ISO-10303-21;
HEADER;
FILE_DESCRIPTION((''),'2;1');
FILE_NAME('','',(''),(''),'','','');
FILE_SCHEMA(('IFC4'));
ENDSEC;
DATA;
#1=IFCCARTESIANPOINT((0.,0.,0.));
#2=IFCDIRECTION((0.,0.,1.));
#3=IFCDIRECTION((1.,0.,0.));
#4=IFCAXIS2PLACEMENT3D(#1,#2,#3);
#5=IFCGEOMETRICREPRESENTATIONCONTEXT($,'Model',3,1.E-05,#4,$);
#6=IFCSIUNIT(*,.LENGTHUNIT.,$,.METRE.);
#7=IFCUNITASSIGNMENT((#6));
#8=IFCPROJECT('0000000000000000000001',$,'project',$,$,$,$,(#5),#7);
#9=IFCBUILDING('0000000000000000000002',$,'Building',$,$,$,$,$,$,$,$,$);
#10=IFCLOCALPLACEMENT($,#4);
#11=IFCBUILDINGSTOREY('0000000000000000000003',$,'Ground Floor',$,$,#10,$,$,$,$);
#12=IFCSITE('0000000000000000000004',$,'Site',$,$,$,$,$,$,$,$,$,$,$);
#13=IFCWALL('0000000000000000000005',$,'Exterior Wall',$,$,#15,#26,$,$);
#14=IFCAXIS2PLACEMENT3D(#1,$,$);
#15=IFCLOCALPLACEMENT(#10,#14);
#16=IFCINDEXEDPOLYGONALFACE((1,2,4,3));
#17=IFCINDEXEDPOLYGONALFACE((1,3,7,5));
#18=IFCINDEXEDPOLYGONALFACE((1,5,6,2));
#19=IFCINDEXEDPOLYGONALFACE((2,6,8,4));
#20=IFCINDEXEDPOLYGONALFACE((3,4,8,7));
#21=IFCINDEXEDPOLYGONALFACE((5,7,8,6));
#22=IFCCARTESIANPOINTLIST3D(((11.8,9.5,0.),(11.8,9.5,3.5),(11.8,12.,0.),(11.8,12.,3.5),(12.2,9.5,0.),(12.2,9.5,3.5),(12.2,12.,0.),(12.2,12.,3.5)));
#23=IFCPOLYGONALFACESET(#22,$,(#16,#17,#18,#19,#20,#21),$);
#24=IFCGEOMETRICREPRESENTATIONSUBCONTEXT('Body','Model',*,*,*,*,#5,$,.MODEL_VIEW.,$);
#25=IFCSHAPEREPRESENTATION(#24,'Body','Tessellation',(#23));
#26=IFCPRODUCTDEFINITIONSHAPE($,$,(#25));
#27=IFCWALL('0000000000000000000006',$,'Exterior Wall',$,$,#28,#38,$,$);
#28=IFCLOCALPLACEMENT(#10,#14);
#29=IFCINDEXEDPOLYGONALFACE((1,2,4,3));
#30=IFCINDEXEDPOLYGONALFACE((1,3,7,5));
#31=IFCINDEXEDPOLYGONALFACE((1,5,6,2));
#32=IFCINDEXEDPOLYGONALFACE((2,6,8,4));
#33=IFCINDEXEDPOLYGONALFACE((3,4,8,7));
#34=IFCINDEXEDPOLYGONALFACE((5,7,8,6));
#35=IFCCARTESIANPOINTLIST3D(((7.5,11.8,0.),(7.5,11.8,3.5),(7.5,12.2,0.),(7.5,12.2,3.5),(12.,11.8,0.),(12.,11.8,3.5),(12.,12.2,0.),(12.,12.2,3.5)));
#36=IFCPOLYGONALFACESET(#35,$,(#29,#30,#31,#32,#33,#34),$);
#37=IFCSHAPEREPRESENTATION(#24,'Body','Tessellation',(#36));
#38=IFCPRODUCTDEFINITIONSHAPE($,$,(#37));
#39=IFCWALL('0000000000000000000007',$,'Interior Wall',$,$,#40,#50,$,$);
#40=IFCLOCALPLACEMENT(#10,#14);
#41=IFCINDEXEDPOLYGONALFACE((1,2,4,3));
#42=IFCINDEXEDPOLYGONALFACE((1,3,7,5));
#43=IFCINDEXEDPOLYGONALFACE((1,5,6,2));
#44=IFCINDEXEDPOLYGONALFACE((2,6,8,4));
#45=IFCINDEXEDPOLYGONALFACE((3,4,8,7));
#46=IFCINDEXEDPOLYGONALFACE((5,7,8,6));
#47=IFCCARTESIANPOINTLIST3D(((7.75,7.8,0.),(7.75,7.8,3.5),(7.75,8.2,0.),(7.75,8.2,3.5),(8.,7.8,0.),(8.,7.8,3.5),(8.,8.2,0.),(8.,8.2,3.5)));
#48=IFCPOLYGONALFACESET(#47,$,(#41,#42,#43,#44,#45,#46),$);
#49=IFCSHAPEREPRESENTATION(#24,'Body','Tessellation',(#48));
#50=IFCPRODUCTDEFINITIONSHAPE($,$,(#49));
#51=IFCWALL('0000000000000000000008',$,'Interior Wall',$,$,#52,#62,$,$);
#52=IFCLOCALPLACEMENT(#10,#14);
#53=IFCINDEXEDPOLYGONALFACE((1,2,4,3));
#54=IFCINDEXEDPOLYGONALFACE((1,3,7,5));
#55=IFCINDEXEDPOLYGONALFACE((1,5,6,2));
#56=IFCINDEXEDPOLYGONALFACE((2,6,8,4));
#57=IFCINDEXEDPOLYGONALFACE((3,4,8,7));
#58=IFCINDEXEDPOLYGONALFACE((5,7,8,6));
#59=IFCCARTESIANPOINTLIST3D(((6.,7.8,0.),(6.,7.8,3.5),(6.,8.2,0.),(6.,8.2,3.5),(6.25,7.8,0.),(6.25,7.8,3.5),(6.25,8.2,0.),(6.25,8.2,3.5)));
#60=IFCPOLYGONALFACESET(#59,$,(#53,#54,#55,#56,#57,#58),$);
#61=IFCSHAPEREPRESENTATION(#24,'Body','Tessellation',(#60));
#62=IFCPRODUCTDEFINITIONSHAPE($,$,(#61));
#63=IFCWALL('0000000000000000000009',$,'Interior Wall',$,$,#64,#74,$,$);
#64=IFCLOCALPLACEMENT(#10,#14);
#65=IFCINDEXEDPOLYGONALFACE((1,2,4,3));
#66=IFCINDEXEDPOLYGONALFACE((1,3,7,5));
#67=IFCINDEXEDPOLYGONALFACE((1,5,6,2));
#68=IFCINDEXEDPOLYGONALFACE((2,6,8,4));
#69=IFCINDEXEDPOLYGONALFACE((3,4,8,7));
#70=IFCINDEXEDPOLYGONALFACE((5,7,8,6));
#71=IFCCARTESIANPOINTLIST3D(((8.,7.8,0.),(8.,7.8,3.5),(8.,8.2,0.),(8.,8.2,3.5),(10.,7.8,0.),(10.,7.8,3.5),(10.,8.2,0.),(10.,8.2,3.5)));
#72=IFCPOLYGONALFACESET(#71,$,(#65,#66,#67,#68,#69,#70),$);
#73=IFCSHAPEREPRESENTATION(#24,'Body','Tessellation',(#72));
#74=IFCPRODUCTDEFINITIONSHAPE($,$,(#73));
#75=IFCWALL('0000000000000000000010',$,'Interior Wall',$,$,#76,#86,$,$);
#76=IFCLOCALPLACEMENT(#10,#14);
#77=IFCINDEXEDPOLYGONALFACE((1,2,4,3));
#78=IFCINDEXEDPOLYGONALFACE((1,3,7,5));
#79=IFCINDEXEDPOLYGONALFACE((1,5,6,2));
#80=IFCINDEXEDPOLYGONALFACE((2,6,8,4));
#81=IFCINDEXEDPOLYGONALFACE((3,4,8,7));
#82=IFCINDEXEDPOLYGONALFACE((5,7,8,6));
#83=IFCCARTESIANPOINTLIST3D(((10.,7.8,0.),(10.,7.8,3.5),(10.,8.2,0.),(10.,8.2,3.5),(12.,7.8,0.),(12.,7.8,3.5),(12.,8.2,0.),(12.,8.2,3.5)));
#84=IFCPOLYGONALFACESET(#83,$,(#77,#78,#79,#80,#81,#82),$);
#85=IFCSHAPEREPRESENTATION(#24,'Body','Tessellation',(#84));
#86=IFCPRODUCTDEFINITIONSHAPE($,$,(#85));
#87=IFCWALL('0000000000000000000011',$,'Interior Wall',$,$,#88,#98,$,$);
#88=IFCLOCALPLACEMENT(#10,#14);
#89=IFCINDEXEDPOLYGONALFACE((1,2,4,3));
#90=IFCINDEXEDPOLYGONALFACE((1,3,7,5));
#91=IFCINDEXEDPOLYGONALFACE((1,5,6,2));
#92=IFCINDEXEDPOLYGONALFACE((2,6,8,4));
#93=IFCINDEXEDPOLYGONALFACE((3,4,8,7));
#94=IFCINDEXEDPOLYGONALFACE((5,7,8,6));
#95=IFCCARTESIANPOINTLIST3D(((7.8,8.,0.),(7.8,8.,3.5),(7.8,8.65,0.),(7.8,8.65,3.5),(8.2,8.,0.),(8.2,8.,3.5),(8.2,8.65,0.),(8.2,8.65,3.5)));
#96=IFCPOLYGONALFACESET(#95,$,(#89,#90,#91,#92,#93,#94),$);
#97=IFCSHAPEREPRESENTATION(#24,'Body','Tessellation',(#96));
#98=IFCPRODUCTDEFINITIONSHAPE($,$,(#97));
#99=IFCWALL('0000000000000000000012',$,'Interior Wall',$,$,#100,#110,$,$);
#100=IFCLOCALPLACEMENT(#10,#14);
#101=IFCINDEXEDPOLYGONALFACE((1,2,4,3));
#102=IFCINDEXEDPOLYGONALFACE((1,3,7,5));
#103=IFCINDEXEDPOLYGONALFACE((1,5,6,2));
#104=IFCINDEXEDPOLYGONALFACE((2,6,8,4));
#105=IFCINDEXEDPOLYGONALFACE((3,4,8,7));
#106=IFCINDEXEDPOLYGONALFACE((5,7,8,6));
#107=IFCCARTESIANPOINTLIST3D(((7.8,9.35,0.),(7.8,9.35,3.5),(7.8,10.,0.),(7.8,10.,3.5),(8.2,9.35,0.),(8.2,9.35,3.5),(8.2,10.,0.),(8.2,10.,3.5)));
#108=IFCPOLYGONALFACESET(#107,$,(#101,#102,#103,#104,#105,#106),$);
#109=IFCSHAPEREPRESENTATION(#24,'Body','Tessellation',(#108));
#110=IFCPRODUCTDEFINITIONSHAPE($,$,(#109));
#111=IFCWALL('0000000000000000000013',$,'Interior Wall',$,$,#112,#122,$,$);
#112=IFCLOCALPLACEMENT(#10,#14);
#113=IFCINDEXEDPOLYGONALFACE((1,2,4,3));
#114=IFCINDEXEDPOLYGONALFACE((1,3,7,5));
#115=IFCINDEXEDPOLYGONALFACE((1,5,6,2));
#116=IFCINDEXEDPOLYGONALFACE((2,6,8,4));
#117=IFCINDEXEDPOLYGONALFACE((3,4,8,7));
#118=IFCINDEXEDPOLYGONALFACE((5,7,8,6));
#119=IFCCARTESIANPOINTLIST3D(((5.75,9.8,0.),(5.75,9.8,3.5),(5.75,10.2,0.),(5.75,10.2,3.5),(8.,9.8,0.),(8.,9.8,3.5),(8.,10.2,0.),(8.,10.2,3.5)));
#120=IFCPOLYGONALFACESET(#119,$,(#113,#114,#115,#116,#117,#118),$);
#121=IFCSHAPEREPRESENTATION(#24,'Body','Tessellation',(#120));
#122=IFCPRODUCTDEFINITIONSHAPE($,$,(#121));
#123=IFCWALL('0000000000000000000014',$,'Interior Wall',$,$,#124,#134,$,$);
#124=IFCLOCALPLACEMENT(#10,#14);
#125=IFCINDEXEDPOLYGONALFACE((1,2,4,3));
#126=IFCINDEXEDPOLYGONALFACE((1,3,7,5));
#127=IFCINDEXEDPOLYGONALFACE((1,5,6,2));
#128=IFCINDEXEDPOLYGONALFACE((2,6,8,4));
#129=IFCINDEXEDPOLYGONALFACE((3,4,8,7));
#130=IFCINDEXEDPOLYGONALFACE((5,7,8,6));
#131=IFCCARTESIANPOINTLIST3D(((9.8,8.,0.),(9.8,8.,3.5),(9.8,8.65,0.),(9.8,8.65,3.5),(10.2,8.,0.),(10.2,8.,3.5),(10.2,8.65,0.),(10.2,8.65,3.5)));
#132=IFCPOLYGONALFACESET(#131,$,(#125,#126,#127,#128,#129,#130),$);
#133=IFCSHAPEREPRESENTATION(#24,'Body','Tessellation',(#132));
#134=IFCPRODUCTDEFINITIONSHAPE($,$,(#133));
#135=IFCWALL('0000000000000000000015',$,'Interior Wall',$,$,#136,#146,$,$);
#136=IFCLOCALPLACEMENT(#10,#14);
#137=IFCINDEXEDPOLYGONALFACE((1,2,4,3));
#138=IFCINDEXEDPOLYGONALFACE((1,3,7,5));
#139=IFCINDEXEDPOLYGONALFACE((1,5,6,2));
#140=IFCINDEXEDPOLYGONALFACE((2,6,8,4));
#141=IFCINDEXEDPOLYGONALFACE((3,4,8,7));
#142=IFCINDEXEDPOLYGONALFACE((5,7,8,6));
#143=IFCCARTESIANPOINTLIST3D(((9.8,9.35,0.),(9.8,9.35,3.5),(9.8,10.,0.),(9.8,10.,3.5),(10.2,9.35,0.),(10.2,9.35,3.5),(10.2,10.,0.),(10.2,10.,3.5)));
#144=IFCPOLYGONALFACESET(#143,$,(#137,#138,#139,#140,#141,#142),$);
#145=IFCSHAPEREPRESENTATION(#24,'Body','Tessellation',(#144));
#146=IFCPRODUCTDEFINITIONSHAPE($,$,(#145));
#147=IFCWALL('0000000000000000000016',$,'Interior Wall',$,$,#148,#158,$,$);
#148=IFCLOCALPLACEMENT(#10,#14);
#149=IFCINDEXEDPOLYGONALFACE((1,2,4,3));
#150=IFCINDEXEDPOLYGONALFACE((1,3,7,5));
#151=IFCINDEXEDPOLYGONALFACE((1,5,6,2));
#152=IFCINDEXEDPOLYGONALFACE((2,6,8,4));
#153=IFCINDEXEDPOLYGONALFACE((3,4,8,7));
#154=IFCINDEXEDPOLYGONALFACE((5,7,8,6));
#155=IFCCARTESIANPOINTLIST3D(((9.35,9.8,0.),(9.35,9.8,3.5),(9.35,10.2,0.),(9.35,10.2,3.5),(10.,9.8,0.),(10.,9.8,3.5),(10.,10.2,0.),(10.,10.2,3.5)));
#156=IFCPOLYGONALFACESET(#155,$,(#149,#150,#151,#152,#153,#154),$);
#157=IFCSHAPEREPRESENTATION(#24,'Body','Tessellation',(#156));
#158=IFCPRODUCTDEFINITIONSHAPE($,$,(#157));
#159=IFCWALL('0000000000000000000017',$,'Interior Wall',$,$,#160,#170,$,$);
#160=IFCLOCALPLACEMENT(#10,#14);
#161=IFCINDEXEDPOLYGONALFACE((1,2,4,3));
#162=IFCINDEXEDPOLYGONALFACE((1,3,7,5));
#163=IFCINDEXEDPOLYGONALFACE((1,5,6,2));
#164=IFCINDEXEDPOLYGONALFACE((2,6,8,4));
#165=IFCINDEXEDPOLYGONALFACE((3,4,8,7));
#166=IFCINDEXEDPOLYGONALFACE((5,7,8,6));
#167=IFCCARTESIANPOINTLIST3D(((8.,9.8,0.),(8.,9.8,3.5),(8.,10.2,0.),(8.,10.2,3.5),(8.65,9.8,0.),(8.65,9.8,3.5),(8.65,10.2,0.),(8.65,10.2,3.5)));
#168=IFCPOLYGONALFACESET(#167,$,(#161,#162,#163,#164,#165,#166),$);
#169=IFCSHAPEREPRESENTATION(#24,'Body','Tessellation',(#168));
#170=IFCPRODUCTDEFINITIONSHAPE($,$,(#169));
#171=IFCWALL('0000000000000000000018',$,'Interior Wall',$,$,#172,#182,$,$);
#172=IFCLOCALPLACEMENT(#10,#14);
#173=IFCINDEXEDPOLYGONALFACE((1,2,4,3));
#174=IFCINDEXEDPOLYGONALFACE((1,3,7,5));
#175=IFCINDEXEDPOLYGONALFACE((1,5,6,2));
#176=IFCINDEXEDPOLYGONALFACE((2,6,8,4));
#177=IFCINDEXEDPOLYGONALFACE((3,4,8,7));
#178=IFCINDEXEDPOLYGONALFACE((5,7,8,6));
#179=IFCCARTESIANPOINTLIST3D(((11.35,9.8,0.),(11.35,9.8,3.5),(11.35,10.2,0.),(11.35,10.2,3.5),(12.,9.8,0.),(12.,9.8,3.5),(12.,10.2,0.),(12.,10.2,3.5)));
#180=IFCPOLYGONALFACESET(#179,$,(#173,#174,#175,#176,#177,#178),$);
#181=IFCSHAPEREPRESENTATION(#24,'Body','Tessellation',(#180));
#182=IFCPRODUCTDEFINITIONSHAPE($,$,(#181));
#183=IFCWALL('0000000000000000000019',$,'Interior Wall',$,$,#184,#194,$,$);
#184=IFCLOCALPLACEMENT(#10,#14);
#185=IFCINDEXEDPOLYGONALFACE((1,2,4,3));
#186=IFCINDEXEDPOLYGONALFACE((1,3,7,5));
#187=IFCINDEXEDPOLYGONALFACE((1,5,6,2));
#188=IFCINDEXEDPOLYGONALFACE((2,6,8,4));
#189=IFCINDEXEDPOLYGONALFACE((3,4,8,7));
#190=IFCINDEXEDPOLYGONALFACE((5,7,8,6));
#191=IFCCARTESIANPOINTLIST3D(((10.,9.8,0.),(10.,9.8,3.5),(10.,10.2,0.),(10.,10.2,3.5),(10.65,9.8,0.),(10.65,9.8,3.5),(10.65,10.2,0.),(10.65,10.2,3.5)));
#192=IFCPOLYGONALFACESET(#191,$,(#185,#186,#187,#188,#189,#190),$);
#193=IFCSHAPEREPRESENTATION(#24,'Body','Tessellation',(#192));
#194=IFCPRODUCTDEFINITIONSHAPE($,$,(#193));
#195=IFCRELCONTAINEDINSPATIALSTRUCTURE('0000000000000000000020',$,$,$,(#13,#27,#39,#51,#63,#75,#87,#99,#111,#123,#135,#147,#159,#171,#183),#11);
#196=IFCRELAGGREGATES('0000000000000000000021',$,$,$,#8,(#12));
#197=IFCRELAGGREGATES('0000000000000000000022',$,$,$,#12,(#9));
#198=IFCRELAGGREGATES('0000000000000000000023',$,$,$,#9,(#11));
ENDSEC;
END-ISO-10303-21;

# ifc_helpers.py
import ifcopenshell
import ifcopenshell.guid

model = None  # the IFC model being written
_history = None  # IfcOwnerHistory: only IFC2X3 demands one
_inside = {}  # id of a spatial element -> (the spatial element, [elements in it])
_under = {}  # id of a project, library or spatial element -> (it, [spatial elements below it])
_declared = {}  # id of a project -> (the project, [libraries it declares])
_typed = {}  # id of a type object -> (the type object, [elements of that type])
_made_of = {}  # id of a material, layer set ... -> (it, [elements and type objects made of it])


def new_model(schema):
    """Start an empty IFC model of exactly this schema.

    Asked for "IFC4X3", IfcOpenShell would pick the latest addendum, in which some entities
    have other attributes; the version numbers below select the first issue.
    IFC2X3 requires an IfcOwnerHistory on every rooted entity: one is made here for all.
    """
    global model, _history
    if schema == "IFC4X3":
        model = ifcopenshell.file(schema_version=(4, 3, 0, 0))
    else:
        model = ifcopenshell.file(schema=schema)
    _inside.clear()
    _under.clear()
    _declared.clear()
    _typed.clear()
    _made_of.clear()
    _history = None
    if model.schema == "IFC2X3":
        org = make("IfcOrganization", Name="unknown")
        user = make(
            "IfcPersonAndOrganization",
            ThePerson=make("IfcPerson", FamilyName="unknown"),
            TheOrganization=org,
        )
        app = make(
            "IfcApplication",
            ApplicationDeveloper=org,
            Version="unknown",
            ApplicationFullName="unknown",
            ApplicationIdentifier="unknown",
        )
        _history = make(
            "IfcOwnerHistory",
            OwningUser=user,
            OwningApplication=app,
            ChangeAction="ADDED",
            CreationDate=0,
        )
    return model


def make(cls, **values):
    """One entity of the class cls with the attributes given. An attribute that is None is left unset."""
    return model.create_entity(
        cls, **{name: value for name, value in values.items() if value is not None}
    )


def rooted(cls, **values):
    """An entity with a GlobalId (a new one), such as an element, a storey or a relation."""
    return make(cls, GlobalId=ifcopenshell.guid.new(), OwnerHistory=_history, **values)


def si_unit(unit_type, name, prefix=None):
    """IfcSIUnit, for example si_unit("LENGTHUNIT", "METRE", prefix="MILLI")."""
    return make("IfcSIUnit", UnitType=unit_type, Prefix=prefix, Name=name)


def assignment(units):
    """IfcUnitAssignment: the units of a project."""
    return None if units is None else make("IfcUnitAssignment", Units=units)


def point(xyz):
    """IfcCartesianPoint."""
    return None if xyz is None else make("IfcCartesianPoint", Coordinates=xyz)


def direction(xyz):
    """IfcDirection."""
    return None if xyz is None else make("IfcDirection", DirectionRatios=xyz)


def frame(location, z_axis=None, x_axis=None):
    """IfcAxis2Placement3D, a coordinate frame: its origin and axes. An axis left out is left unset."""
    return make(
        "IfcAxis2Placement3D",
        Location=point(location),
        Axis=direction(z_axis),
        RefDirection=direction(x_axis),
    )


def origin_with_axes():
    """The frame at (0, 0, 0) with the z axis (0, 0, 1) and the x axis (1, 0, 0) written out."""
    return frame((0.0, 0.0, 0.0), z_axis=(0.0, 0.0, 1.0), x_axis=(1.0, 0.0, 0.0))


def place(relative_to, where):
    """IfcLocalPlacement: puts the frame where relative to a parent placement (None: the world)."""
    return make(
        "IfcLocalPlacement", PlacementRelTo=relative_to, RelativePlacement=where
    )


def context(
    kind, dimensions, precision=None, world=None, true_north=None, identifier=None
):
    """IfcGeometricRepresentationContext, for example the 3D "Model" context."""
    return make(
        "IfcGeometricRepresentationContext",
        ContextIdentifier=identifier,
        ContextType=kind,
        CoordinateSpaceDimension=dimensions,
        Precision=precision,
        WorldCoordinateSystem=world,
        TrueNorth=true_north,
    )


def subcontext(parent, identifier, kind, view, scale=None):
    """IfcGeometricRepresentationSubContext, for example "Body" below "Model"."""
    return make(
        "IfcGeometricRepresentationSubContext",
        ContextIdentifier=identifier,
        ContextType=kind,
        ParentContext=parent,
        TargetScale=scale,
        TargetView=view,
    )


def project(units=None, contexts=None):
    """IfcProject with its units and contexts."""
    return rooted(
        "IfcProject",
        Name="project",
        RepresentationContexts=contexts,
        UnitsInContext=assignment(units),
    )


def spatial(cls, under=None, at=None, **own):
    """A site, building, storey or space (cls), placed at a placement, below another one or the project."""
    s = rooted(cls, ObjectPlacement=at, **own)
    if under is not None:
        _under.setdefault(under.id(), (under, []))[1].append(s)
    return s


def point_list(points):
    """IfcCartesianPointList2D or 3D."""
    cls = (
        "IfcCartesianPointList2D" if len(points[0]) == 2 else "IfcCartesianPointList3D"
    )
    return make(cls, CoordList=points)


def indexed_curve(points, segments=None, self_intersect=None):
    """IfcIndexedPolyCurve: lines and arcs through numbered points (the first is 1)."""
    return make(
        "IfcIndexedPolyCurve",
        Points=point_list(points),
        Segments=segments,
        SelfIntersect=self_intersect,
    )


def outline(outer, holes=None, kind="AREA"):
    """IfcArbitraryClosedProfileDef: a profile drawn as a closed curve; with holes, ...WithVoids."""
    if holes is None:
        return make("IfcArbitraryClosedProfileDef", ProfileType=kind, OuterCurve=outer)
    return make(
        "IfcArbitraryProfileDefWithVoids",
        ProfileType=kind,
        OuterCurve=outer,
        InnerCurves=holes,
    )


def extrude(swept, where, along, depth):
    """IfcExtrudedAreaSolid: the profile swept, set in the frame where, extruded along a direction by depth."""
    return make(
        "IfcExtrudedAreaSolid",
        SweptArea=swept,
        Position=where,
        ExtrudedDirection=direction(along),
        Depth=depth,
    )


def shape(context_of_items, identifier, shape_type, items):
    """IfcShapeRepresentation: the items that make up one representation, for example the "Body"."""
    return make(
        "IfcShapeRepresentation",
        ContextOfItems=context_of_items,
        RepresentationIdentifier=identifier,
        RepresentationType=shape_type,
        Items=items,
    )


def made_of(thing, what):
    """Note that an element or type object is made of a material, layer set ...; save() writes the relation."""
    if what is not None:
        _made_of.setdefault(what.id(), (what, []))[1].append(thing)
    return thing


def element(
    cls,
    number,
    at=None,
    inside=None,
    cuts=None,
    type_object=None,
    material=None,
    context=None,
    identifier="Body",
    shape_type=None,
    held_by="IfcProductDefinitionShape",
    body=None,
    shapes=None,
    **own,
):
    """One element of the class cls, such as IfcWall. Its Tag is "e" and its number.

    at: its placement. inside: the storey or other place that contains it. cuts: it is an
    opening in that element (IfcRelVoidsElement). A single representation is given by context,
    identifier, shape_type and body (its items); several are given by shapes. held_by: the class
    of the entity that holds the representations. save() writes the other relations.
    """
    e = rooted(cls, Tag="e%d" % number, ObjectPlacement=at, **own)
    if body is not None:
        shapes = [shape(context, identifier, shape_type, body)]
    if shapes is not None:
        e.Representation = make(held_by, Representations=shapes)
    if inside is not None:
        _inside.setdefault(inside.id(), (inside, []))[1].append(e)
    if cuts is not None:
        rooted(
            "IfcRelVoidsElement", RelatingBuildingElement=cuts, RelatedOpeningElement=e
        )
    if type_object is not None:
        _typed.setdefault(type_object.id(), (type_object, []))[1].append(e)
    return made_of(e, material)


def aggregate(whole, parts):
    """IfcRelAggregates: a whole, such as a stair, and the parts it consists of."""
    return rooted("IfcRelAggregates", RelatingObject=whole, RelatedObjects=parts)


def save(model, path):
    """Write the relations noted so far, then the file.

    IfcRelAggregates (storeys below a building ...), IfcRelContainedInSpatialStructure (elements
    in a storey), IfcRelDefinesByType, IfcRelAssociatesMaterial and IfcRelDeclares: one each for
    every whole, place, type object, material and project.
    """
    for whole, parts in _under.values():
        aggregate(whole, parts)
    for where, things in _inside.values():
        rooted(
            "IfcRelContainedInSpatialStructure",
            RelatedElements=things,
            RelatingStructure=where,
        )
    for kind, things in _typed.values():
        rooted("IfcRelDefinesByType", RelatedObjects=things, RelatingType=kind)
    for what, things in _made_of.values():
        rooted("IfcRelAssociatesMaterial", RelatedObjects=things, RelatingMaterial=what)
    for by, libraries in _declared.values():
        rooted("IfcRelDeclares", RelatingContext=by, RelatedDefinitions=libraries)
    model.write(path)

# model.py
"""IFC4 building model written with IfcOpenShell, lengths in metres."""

from ifc_helpers import new_model, si_unit, frame, origin_with_axes, place, context, subcontext, project, spatial, indexed_curve, outline, extrude, element, save


model = new_model("IFC4")

# Units and contexts
model_context = context("Model", 3, precision=1e-05, world=origin_with_axes())
body_context = subcontext(model_context, "Body", "Model", "MODEL_VIEW")
ifc_project = project(units=[si_unit("LENGTHUNIT", "METRE")], contexts=[model_context])

# Site, building, storey
site = spatial("IfcSite", under=ifc_project, Name="Site")
building = spatial("IfcBuilding", under=site, Name="Building")
storey_placement = place(None, origin_with_axes())
storey = spatial("IfcBuildingStorey", under=building, at=storey_placement, Name="Ground Floor")

# Walls
wall_1_placement = place(storey_placement, frame((12.0, 9.5, 0.0), z_axis=(0.0, 0.0, 1.0), x_axis=(0.0, 1.0, 0.0)))
element("IfcWall", 1, at=wall_1_placement, inside=storey, Name="Exterior Wall", context=body_context, shape_type="SweptSolid", body=[
    extrude(outline(indexed_curve([(0.0, 0.0), (0.0, 0.4), (2.5, 0.4), (2.5, 0.0), (0.0, 0.0)], self_intersect=False)), frame((0.0, -0.2, 0.0), z_axis=(0.0, 0.0, 1.0), x_axis=(1.0, 0.0, 0.0)), (0.0, 0.0, 1.0), 3.5),
])
wall_2_placement = place(storey_placement, frame((12.0, 12.0, 0.0), z_axis=(0.0, 0.0, 1.0), x_axis=(-1.0, 0.0, 0.0)))
element("IfcWall", 2, at=wall_2_placement, inside=storey, Name="Exterior Wall", context=body_context, shape_type="SweptSolid", body=[
    extrude(outline(indexed_curve([(0.0, 0.0), (0.0, 0.4), (4.5, 0.4), (4.5, 0.0), (0.0, 0.0)], self_intersect=False)), frame((0.0, -0.2, 0.0), z_axis=(0.0, 0.0, 1.0), x_axis=(1.0, 0.0, 0.0)), (0.0, 0.0, 1.0), 3.5),
])
for number, where, z_axis, x_axis, name in (
    (3, (8.0, 8.0, 0.0), (0.0, 0.0, 1.0), (-1.0, 0.0, 0.0), "Interior Wall"),
    (4, (6.25, 8.0, 0.0), (0.0, 0.0, 1.0), (-1.0, 0.0, 0.0), "Interior Wall"),
):
    element("IfcWall", number, at=place(storey_placement, frame(where, z_axis=z_axis, x_axis=x_axis)), inside=storey, Name=name, context=body_context, shape_type="SweptSolid", body=[
        extrude(outline(indexed_curve([(0.0, 0.0), (0.0, 0.4), (0.25, 0.4), (0.25, 0.0), (0.0, 0.0)], self_intersect=False)), frame((0.0, -0.2, 0.0), z_axis=(0.0, 0.0, 1.0), x_axis=(1.0, 0.0, 0.0)), (0.0, 0.0, 1.0), 3.5),
    ])
for number, where, z_axis, x_axis, name in (
    (5, (10.0, 8.0, 0.0), (0.0, 0.0, 1.0), (-1.0, 0.0, 0.0), "Interior Wall"),
    (6, (12.0, 8.0, 0.0), (0.0, 0.0, 1.0), (-1.0, 0.0, 0.0), "Interior Wall"),
):
    element("IfcWall", number, at=place(storey_placement, frame(where, z_axis=z_axis, x_axis=x_axis)), inside=storey, Name=name, context=body_context, shape_type="SweptSolid", body=[
        extrude(outline(indexed_curve([(0.0, 0.0), (0.0, 0.4), (2.0, 0.4), (2.0, 0.0), (0.0, 0.0)], self_intersect=False)), frame((0.0, -0.2, 0.0), z_axis=(0.0, 0.0, 1.0), x_axis=(1.0, 0.0, 0.0)), (0.0, 0.0, 1.0), 3.5),
    ])
for number, where, z_axis, x_axis, name in (
    (7, (8.0, 8.0, 0.0), (0.0, 0.0, 1.0), (0.0, 1.0, 0.0), "Interior Wall"),
    (8, (8.0, 9.35, 0.0), (0.0, 0.0, 1.0), (0.0, 1.0, 0.0), "Interior Wall"),
):
    element("IfcWall", number, at=place(storey_placement, frame(where, z_axis=z_axis, x_axis=x_axis)), inside=storey, Name=name, context=body_context, shape_type="SweptSolid", body=[
        extrude(outline(indexed_curve([(0.0, 0.0), (0.0, 0.4), (0.65, 0.4), (0.65, 0.0), (0.0, 0.0)], self_intersect=False)), frame((0.0, -0.2, 0.0), z_axis=(0.0, 0.0, 1.0), x_axis=(1.0, 0.0, 0.0)), (0.0, 0.0, 1.0), 3.5),
    ])
wall_3_placement = place(storey_placement, frame((8.0, 10.0, 0.0), z_axis=(0.0, 0.0, 1.0), x_axis=(-1.0, 0.0, 0.0)))
element("IfcWall", 9, at=wall_3_placement, inside=storey, Name="Interior Wall", context=body_context, shape_type="SweptSolid", body=[
    extrude(outline(indexed_curve([(0.0, 0.0), (0.0, 0.4), (2.25, 0.4), (2.25, 0.0), (0.0, 0.0)], self_intersect=False)), frame((0.0, -0.2, 0.0), z_axis=(0.0, 0.0, 1.0), x_axis=(1.0, 0.0, 0.0)), (0.0, 0.0, 1.0), 3.5),
])
for number, where, z_axis, x_axis, name in (
    (10, (10.0, 8.0, 0.0), (0.0, 0.0, 1.0), (0.0, 1.0, 0.0), "Interior Wall"),
    (11, (10.0, 9.35, 0.0), (0.0, 0.0, 1.0), (0.0, 1.0, 0.0), "Interior Wall"),
    (12, (10.0, 10.0, 0.0), (0.0, 0.0, 1.0), (-1.0, 0.0, 0.0), "Interior Wall"),
    (13, (8.65, 10.0, 0.0), (0.0, 0.0, 1.0), (-1.0, 0.0, 0.0), "Interior Wall"),
    (14, (12.0, 10.0, 0.0), (0.0, 0.0, 1.0), (-1.0, 0.0, 0.0), "Interior Wall"),
    (15, (10.65, 10.0, 0.0), (0.0, 0.0, 1.0), (-1.0, 0.0, 0.0), "Interior Wall"),
):
    element("IfcWall", number, at=place(storey_placement, frame(where, z_axis=z_axis, x_axis=x_axis)), inside=storey, Name=name, context=body_context, shape_type="SweptSolid", body=[
        extrude(outline(indexed_curve([(0.0, 0.0), (0.0, 0.4), (0.65, 0.4), (0.65, 0.0), (0.0, 0.0)], self_intersect=False)), frame((0.0, -0.2, 0.0), z_axis=(0.0, 0.0, 1.0), x_axis=(1.0, 0.0, 0.0)), (0.0, 0.0, 1.0), 3.5),
    ])

save(model, "model.ifc")
